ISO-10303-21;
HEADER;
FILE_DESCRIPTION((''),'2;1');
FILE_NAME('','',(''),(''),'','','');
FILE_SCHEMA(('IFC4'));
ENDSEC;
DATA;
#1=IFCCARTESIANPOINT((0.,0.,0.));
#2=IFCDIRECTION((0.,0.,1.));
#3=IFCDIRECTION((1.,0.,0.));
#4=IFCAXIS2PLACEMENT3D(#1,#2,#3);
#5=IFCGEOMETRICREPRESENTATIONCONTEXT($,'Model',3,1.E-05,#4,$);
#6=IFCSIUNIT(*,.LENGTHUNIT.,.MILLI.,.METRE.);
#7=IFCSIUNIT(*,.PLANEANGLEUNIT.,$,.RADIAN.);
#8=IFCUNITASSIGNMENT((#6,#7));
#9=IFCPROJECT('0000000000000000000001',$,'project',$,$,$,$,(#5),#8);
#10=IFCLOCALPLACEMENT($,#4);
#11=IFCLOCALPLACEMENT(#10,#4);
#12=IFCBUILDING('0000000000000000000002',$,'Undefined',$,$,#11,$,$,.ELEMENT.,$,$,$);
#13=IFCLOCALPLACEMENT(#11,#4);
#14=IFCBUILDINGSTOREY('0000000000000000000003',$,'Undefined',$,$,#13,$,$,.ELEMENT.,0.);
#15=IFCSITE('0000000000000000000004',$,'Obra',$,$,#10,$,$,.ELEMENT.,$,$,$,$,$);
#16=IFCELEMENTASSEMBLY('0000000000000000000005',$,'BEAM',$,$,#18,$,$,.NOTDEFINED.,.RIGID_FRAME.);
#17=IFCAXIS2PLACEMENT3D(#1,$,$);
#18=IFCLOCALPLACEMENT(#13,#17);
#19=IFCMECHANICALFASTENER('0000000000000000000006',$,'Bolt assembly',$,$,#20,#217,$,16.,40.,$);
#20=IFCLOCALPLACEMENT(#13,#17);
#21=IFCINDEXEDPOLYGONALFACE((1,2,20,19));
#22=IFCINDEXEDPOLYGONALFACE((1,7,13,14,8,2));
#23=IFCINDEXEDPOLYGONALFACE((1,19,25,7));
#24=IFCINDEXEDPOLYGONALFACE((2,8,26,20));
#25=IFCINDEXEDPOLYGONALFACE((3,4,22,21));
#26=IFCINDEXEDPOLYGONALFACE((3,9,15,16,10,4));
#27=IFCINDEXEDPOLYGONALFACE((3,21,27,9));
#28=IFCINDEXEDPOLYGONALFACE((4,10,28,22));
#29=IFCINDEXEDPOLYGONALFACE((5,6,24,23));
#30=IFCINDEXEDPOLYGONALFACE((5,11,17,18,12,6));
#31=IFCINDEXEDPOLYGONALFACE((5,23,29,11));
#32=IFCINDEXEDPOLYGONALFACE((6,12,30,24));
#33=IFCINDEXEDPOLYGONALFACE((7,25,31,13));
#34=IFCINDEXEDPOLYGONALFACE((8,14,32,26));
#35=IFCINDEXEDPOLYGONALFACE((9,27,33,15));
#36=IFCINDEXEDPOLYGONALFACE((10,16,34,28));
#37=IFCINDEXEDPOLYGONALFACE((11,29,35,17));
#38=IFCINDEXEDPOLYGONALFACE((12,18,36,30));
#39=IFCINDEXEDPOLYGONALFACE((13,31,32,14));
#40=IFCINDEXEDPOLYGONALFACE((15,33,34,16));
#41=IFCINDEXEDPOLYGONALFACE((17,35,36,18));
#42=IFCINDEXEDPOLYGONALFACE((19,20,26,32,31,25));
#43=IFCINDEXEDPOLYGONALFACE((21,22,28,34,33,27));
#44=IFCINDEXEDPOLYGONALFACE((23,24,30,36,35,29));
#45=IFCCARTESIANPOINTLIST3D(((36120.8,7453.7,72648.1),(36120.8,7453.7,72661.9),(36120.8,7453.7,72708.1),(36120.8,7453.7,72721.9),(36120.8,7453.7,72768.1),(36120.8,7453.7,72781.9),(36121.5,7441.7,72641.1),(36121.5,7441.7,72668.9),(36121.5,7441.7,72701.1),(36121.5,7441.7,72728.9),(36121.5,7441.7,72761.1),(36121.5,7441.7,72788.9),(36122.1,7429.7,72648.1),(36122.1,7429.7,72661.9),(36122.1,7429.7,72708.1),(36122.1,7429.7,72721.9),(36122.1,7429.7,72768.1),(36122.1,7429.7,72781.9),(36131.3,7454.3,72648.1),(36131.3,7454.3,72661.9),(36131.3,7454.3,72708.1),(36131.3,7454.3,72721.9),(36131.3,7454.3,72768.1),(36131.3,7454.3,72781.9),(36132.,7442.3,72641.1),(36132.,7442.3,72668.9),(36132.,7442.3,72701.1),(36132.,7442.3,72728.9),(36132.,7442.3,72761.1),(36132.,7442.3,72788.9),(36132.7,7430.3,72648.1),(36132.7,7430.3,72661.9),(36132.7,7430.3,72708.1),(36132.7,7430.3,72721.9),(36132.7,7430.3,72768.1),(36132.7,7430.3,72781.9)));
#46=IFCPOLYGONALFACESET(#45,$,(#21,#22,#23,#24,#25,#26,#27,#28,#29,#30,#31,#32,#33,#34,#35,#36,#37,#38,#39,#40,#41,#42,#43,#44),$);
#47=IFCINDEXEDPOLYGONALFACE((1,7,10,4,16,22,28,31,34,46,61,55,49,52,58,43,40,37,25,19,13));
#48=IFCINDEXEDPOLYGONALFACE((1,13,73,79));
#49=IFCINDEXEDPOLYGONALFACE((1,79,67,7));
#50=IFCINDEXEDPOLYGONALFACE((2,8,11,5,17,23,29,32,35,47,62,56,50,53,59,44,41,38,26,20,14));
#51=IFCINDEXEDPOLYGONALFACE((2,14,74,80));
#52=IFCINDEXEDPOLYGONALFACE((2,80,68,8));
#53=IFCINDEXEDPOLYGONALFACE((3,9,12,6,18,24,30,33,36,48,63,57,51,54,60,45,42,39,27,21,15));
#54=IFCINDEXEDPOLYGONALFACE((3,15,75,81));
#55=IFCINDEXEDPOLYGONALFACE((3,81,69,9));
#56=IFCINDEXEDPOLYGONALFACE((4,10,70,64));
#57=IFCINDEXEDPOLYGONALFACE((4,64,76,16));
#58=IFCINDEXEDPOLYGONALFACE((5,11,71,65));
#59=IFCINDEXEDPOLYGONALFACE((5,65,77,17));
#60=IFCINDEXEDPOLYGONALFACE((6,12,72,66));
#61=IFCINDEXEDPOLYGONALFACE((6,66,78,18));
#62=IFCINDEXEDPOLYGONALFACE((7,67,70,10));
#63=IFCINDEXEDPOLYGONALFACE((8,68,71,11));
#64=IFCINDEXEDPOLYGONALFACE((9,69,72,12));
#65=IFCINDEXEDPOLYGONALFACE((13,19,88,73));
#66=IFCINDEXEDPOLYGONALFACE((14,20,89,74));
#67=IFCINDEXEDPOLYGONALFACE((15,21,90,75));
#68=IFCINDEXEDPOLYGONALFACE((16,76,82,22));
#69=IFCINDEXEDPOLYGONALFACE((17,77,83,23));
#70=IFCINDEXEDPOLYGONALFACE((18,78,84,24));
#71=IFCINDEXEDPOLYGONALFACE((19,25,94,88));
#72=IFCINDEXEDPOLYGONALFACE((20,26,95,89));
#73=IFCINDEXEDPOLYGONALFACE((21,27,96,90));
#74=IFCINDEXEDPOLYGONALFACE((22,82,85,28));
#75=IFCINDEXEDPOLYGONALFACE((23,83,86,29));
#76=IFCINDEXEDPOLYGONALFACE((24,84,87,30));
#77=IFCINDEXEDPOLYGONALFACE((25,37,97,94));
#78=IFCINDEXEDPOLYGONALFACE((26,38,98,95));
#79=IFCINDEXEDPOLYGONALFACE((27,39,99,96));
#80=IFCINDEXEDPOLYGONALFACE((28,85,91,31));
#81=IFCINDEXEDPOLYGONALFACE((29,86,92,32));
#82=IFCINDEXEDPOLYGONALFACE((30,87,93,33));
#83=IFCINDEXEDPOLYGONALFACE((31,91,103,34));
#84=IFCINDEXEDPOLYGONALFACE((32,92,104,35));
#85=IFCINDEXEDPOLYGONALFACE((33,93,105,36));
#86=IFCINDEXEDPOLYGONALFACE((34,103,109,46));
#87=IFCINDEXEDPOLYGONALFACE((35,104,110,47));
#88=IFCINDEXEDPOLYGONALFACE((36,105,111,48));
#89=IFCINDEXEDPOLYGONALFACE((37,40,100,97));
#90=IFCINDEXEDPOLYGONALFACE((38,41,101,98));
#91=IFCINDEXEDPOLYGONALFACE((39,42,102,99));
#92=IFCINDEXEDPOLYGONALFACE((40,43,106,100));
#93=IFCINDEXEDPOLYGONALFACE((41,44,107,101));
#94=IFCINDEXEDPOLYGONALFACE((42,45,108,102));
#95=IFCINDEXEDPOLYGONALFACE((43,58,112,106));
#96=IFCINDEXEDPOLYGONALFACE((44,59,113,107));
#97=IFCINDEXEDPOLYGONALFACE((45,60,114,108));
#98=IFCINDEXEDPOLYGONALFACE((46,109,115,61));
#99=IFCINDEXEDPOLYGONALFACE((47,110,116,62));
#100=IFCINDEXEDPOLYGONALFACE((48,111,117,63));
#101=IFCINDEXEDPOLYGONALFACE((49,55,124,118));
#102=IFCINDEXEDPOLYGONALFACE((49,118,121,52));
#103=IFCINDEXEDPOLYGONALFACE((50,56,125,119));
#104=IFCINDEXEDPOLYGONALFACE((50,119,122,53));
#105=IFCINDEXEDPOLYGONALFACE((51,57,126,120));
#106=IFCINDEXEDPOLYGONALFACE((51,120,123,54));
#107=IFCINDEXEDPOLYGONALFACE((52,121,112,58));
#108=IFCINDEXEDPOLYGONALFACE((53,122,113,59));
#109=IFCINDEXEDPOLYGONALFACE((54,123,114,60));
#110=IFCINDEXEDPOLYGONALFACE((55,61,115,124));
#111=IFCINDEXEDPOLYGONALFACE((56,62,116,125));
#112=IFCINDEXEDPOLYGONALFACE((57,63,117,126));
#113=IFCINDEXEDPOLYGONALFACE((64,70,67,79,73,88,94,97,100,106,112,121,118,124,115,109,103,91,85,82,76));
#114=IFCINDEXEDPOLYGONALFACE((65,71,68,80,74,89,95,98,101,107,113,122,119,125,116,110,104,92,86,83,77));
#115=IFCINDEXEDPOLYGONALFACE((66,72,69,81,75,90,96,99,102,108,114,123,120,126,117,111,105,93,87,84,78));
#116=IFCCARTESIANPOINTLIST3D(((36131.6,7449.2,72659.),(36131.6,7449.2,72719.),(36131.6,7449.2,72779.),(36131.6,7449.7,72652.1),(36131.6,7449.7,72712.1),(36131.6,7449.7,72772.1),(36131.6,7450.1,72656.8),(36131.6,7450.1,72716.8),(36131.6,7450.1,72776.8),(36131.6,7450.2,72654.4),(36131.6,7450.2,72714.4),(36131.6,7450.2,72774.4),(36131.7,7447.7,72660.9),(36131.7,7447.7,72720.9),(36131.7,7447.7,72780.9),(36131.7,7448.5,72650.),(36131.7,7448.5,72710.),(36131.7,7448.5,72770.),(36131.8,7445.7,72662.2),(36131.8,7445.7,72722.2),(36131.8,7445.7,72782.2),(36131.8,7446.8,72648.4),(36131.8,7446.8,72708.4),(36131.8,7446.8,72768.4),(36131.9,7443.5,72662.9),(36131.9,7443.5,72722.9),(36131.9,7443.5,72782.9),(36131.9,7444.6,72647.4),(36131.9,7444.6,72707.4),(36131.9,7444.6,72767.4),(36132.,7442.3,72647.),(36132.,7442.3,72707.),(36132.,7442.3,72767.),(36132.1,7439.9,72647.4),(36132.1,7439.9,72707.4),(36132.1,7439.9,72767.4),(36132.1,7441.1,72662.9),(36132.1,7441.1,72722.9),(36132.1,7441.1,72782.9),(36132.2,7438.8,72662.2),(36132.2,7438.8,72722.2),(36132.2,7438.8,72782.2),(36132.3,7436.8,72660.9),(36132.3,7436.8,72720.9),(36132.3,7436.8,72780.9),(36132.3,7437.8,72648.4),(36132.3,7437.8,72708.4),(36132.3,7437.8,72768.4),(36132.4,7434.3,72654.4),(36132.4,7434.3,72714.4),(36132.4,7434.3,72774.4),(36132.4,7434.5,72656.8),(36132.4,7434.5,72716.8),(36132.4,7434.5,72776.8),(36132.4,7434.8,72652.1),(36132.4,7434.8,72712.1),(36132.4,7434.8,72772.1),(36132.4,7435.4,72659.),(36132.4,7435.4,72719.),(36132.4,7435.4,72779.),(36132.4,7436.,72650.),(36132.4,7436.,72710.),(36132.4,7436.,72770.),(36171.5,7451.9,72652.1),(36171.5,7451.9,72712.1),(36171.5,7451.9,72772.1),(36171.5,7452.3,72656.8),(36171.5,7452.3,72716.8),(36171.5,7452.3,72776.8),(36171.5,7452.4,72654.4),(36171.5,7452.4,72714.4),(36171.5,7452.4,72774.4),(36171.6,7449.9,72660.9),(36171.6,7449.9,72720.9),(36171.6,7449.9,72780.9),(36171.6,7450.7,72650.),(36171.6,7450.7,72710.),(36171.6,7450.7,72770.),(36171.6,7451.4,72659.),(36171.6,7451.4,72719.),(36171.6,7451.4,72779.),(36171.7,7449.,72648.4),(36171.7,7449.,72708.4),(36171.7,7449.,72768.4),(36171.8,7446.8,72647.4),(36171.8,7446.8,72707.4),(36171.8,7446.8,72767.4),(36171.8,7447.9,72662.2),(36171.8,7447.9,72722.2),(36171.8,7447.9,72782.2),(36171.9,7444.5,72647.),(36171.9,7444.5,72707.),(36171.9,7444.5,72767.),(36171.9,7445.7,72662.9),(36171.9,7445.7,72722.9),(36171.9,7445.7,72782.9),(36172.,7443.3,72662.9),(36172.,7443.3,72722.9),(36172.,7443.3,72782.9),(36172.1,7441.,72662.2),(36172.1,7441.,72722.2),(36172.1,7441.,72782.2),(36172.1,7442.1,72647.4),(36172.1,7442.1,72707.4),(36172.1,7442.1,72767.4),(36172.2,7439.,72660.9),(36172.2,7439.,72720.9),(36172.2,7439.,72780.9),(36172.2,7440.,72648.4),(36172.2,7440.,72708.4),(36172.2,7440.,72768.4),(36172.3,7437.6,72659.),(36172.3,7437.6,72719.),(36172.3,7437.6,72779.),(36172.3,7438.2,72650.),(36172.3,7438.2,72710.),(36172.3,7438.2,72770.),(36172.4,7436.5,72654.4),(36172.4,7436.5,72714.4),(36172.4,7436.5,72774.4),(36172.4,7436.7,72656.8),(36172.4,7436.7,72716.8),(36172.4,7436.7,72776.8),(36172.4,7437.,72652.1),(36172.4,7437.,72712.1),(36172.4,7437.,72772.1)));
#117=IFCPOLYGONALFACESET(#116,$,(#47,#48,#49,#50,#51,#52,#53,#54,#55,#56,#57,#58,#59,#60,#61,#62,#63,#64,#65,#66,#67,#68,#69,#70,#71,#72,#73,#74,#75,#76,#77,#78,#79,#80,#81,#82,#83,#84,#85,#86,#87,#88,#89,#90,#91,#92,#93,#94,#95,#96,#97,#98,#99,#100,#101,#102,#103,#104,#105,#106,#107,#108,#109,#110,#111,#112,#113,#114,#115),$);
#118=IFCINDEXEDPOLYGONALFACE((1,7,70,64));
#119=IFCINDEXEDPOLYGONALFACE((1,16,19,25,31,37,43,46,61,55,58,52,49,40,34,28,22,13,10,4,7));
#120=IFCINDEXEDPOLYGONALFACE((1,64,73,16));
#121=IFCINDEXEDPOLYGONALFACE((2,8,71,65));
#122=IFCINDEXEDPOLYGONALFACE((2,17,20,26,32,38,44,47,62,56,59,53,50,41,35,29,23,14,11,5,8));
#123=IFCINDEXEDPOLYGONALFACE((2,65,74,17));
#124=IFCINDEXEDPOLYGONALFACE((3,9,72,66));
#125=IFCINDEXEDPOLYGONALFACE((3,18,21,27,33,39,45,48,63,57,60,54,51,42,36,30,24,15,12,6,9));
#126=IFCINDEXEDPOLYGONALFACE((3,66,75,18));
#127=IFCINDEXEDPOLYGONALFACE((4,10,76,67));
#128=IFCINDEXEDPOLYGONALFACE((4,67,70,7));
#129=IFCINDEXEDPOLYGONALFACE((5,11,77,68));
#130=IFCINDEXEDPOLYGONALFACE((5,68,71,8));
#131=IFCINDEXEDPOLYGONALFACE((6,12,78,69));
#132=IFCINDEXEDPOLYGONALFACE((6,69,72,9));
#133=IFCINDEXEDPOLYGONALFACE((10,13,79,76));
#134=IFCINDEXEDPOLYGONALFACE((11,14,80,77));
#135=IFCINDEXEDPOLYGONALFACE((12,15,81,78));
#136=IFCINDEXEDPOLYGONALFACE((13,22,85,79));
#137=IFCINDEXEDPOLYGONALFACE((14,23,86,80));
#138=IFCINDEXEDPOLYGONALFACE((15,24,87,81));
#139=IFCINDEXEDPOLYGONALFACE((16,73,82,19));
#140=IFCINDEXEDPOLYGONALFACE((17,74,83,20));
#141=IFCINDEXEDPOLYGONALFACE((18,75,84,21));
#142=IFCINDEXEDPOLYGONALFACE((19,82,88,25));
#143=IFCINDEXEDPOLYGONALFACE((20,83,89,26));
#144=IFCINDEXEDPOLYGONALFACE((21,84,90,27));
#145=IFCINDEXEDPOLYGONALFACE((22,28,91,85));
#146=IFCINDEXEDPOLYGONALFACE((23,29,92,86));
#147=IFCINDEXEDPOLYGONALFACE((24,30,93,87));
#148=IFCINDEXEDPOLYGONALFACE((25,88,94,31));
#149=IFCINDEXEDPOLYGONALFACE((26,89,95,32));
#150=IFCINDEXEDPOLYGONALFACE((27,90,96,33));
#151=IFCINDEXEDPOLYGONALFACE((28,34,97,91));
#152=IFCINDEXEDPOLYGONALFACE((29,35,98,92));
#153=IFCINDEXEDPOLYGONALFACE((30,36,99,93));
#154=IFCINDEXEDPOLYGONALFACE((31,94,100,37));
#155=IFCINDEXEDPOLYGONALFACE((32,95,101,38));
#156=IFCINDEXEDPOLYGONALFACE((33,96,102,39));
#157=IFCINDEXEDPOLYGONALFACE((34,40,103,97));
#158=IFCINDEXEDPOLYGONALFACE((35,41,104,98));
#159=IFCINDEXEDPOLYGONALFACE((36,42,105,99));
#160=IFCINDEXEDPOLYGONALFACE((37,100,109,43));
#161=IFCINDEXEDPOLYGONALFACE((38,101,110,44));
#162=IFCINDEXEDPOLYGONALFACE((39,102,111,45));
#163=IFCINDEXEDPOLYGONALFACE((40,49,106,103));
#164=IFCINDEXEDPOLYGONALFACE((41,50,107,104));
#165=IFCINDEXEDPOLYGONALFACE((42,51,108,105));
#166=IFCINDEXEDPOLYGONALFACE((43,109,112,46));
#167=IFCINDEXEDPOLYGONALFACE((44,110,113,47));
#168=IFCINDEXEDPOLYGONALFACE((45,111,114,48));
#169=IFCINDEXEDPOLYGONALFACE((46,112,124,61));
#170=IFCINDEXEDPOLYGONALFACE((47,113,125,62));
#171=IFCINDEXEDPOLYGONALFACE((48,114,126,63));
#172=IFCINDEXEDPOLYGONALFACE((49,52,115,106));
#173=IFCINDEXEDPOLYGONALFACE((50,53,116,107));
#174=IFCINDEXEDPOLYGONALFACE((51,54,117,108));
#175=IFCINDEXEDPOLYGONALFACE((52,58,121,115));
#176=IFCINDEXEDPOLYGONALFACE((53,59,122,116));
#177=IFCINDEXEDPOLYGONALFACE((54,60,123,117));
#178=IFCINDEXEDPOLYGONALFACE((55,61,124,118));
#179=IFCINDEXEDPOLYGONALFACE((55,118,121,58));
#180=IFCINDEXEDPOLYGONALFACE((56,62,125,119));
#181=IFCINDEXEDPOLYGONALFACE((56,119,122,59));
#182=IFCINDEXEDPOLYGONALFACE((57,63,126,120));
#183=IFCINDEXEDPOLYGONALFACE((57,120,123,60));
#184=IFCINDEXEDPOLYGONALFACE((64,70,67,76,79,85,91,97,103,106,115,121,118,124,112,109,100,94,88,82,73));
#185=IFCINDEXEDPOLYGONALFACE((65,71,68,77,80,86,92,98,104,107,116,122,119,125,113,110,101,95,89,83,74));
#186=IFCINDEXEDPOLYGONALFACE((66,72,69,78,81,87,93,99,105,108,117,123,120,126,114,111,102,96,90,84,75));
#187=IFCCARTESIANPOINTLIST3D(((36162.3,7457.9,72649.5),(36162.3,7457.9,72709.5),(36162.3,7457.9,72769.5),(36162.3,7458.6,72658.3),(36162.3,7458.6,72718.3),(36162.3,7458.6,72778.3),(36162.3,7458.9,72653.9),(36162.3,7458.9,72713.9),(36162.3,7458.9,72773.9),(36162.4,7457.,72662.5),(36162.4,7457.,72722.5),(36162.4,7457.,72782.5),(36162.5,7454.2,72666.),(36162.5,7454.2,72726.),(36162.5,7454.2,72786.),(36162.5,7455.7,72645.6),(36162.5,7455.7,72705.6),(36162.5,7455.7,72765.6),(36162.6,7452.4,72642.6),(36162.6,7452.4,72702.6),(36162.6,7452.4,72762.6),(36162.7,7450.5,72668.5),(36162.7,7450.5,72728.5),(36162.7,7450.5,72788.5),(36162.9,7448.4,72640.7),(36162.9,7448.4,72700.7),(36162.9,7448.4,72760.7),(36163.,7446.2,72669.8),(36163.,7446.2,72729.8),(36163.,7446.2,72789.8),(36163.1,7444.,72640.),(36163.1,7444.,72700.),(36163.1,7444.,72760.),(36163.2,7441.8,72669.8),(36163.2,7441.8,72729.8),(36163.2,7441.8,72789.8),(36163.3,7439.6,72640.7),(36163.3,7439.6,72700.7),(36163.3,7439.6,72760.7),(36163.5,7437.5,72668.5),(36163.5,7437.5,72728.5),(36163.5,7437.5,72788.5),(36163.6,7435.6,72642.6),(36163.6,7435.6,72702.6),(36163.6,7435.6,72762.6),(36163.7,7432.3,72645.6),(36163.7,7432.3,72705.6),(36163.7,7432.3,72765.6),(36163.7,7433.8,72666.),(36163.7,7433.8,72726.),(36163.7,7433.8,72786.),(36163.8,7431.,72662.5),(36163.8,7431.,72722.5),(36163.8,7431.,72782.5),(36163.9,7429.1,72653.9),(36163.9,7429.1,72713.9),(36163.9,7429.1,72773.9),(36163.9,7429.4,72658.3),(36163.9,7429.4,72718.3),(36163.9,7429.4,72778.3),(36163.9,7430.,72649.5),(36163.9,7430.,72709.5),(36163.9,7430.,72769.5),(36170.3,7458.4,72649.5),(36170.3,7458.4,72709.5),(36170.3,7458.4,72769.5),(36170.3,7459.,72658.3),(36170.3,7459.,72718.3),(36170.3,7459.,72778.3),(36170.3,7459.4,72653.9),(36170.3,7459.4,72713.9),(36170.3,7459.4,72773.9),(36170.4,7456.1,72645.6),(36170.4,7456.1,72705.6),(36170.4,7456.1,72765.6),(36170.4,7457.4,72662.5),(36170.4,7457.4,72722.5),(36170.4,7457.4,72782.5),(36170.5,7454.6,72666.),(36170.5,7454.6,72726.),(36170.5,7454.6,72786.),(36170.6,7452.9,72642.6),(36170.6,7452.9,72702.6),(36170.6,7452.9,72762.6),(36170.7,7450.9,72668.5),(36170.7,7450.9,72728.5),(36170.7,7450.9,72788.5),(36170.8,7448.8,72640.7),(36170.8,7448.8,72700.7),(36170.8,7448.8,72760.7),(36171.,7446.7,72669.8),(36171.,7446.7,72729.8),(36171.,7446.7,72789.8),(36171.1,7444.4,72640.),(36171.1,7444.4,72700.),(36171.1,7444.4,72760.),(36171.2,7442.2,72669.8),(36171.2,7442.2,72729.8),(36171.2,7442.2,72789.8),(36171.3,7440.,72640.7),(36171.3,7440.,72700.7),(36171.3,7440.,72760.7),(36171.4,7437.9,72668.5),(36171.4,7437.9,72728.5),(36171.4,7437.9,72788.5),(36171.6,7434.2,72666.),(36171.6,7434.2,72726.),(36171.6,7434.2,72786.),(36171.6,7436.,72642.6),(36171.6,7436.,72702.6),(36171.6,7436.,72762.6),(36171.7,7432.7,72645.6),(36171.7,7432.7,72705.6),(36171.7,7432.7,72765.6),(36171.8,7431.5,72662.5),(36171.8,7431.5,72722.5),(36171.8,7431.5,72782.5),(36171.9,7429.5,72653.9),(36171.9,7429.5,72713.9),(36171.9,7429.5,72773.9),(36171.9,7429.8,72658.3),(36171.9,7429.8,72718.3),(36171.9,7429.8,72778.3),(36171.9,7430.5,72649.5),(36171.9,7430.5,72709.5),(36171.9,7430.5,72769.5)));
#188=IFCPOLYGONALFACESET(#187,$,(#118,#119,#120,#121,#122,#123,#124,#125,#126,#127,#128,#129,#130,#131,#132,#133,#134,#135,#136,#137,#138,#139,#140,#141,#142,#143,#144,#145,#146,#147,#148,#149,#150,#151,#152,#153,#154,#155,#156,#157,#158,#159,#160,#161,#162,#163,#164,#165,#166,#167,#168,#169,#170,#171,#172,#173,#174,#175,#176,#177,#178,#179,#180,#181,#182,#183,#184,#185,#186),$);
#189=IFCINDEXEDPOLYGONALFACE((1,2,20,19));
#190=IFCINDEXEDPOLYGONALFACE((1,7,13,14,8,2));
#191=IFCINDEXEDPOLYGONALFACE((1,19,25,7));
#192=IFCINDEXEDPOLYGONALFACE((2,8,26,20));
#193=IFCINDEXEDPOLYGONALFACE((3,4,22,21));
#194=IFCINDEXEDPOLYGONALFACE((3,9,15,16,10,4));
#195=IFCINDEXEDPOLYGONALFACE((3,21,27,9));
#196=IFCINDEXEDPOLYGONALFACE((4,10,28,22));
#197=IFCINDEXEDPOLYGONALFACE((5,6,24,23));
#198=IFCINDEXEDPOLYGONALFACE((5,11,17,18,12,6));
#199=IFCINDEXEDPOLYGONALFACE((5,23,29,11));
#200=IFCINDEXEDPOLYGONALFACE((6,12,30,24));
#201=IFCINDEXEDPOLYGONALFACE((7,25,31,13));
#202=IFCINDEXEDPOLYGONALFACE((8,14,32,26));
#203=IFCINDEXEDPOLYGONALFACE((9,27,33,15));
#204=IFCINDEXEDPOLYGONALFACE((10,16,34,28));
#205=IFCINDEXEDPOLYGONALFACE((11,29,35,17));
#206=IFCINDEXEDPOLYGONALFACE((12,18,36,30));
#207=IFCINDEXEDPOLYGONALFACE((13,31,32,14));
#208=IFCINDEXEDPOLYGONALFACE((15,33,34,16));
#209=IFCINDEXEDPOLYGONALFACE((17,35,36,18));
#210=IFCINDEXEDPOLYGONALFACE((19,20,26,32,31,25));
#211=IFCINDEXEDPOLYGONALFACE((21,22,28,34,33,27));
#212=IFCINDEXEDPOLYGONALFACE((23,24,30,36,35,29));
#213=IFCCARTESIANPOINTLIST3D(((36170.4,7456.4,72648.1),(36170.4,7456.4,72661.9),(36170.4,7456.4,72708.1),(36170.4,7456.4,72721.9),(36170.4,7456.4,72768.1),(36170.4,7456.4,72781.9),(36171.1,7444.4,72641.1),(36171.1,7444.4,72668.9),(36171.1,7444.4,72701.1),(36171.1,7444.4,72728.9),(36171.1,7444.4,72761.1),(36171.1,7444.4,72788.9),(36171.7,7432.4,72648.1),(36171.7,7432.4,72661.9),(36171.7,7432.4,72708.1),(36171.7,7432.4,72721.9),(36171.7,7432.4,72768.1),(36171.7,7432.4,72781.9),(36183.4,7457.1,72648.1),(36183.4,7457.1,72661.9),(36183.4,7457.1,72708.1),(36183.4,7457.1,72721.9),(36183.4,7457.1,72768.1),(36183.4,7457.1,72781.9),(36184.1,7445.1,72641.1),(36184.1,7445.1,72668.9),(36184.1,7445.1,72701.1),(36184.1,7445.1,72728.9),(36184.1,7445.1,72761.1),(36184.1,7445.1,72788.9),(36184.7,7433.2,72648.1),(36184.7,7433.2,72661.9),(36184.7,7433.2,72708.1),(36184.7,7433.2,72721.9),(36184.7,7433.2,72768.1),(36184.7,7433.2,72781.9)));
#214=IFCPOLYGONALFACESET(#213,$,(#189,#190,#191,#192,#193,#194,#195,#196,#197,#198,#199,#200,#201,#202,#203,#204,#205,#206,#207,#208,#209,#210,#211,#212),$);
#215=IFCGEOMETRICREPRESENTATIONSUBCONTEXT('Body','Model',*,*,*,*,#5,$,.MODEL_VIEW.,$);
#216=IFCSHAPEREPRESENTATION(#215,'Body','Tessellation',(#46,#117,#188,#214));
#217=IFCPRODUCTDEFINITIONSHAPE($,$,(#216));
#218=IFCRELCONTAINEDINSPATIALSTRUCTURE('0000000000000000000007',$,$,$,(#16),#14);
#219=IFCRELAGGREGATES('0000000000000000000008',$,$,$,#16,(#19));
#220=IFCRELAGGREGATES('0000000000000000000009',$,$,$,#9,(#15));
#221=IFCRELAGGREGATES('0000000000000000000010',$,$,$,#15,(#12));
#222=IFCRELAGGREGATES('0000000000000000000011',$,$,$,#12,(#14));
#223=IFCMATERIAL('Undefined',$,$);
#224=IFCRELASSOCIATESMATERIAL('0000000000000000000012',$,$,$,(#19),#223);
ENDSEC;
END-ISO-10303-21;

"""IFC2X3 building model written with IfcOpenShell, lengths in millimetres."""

from ifc_helpers import new_model, si_unit, frame, origin_with_axes, origin_2d_with_axis, place, context, subcontext, project, spatial, polyline, circle, outline, extrude, source, transform, mapped, material, element, aggregate, save


model = new_model("IFC2X3")

# Units and contexts
model_context = context("Model", 3, precision=1e-05, world=origin_with_axes())
body_context = subcontext(model_context, "Body", "Model", "MODEL_VIEW")
ifc_project = project(units=[si_unit("LENGTHUNIT", "METRE", prefix="MILLI"), si_unit("PLANEANGLEUNIT", "RADIAN")], contexts=[model_context])

# Site, building, storey
site_placement = place(None, origin_with_axes())
site = spatial("IfcSite", under=ifc_project, at=site_placement, Name="Obra", CompositionType="ELEMENT")
building_placement = place(site_placement, origin_with_axes())
building = spatial("IfcBuilding", under=site, at=building_placement, Name="Undefined", CompositionType="ELEMENT")
storey_placement = place(building_placement, origin_with_axes())
storey = spatial("IfcBuildingStorey", under=building, at=storey_placement, Name="Undefined", CompositionType="ELEMENT", Elevation=0.0)

# Element assembly, mechanical fastener
assembly_1_placement = place(storey_placement, origin_with_axes())
assembly_1 = element("IfcElementAssembly", 1, at=assembly_1_placement, inside=storey, Name="BEAM", AssemblyPlace="NOTDEFINED", PredefinedType="RIGID_FRAME")
ifc_material_1 = material(Name="Undefined")
shared_shape_1 = source(origin_with_axes(), body_context, "Body", "SweptSolid", [
    extrude(outline(polyline([(13.9, 0.0), (6.9, 12.0), (-6.9, 12.0), (-13.9, 0.0), (-6.9, -12.0), (6.9, -12.0), (13.9, 0.0)])), frame((0.0, -44.8, 0.0), z_axis=(0.0, 1.0, 0.0), x_axis=(1.0, 0.0, 0.0)), (0.0, 0.0, 1.0), 10.6),
    extrude(circle(Radius=8.0, at=origin_2d_with_axis()), frame((0.0, -34.2, 0.0), z_axis=(0.0, 1.0, 0.0), x_axis=(1.0, 0.0, 0.0)), (0.0, 0.0, 1.0), 40.0),
    extrude(circle(Radius=15.0, at=origin_2d_with_axis()), frame((0.0, -3.1, 0.0), z_axis=(0.0, 1.0, 0.0), x_axis=(1.0, 0.0, 0.0)), (0.0, 0.0, 1.0), 8.0),
    extrude(outline(polyline([(13.9, 0.0), (6.9, 12.0), (-6.9, 12.0), (-13.9, 0.0), (-6.9, -12.0), (6.9, -12.0), (13.9, 0.0)])), frame((0.0, 4.9, 0.0), z_axis=(0.0, 1.0, 0.0), x_axis=(1.0, 0.0, 0.0)), (0.0, 0.0, 1.0), 13.0),
])
mechanical_fastener_1_placement = place(assembly_1_placement, frame((36163.4, 7494.1, 72835.0), z_axis=(0.055152, -0.998478, 0.0), x_axis=(0.0, 0.0, -1.0)))
mechanical_fastener_1 = element("IfcMechanicalFastener", 2, at=mechanical_fastener_1_placement, material=ifc_material_1, Name="Bolt assembly", NominalDiameter=16.0, NominalLength=40.0, context=body_context, shape_type="MappedRepresentation", body=[
    mapped(shared_shape_1, transform((60.0, 0.0, 50.0))),
    mapped(shared_shape_1, transform((120.0, 0.0, 50.0))),
    mapped(shared_shape_1, transform((180.0, 0.0, 50.0))),
])
aggregate(assembly_1, [mechanical_fastener_1])

save(model, "model.ifc")
